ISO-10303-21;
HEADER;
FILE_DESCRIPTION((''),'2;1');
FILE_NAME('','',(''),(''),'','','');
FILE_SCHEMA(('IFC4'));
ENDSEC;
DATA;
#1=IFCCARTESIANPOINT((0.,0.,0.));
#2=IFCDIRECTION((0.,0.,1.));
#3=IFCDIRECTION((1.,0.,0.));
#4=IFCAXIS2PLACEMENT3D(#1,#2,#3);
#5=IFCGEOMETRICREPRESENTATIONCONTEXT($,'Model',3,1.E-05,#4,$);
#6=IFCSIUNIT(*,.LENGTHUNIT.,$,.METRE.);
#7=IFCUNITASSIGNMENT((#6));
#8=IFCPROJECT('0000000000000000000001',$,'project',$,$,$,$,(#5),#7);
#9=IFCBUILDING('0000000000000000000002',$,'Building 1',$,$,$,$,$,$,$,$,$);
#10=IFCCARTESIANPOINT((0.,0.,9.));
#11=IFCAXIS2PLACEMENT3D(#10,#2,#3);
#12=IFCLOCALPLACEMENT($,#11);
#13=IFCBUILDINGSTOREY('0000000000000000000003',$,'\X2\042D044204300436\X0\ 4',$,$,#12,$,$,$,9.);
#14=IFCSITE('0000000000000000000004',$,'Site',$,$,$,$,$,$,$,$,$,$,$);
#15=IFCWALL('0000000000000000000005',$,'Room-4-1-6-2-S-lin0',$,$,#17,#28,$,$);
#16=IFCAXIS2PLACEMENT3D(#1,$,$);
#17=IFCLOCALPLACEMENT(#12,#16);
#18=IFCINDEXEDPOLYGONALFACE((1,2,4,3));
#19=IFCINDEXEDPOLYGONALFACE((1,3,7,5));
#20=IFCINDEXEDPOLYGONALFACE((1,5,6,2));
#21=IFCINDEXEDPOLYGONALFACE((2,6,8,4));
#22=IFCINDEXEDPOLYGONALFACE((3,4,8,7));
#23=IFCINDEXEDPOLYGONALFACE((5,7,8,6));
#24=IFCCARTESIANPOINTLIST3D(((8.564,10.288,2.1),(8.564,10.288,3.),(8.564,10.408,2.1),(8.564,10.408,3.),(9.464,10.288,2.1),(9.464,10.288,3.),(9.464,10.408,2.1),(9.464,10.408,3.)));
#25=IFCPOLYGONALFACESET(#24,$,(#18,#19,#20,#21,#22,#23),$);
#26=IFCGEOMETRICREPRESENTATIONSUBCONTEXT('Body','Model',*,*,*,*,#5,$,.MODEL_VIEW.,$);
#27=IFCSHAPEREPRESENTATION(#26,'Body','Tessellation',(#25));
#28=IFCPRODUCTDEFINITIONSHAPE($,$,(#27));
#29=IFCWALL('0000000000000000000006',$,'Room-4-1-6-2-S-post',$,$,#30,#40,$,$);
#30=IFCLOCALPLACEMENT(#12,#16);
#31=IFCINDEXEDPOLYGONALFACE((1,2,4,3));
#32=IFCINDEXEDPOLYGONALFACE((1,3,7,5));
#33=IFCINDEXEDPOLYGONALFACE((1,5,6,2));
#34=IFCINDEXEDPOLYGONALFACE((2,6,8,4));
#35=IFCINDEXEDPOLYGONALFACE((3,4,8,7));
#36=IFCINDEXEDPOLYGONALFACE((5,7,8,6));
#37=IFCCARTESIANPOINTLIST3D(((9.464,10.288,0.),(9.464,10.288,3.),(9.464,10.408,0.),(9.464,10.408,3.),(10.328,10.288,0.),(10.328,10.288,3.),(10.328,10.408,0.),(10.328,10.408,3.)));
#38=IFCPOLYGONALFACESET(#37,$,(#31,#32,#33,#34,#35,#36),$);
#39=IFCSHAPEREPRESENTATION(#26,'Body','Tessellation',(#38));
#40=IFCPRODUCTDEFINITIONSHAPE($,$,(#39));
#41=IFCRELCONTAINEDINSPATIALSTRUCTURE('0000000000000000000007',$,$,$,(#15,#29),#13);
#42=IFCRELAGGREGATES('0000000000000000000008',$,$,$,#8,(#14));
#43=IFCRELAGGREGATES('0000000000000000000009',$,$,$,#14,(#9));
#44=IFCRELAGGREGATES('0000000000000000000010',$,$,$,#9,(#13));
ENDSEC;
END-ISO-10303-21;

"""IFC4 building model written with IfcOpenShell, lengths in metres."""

from ifc_helpers import new_model, si_unit, frame, origin_with_axes, place, context, subcontext, project, spatial, indexed_curve, outline, extrude, element, save


model = new_model("IFC4")

# Units and contexts
model_context = context("Model", 3, precision=1e-05, world=origin_with_axes())
body_context = subcontext(model_context, "Body", "Model", "MODEL_VIEW")
ifc_project = project(units=[si_unit("LENGTHUNIT", "METRE")], contexts=[model_context])

# Site, building, storey
site = spatial("IfcSite", under=ifc_project, Name="Site")
building = spatial("IfcBuilding", under=site, Name="Building 1")
storey_placement = place(None, frame((0.0, 0.0, 9.0), z_axis=(0.0, 0.0, 1.0), x_axis=(1.0, 0.0, 0.0)))
storey = spatial("IfcBuildingStorey", under=building, at=storey_placement, Name="Этаж 4", Elevation=9.0)

# Walls
wall_1_placement = place(storey_placement, frame((8.564, 10.288, 2.1), z_axis=(0.0, 0.0, 1.0), x_axis=(1.0, 0.0, 0.0)))
element("IfcWall", 1, at=wall_1_placement, inside=storey, Name="Room-4-1-6-2-S-lin0", context=body_context, shape_type="SweptSolid", body=[
    extrude(outline(indexed_curve([(0.0, 0.0), (0.0, 0.12), (0.9, 0.12), (0.9, 0.0), (0.0, 0.0)], self_intersect=False)), origin_with_axes(), (0.0, 0.0, 1.0), 0.9),
])
wall_2_placement = place(storey_placement, frame((9.464, 10.288, 0.0), z_axis=(0.0, 0.0, 1.0), x_axis=(1.0, 0.0, 0.0)))
element("IfcWall", 2, at=wall_2_placement, inside=storey, Name="Room-4-1-6-2-S-post", context=body_context, shape_type="SweptSolid", body=[
    extrude(outline(indexed_curve([(0.0, 0.0), (0.0, 0.12), (0.864, 0.12), (0.864, 0.0), (0.0, 0.0)], self_intersect=False)), origin_with_axes(), (0.0, 0.0, 1.0), 3.0),
])

save(model, "model.ifc")
